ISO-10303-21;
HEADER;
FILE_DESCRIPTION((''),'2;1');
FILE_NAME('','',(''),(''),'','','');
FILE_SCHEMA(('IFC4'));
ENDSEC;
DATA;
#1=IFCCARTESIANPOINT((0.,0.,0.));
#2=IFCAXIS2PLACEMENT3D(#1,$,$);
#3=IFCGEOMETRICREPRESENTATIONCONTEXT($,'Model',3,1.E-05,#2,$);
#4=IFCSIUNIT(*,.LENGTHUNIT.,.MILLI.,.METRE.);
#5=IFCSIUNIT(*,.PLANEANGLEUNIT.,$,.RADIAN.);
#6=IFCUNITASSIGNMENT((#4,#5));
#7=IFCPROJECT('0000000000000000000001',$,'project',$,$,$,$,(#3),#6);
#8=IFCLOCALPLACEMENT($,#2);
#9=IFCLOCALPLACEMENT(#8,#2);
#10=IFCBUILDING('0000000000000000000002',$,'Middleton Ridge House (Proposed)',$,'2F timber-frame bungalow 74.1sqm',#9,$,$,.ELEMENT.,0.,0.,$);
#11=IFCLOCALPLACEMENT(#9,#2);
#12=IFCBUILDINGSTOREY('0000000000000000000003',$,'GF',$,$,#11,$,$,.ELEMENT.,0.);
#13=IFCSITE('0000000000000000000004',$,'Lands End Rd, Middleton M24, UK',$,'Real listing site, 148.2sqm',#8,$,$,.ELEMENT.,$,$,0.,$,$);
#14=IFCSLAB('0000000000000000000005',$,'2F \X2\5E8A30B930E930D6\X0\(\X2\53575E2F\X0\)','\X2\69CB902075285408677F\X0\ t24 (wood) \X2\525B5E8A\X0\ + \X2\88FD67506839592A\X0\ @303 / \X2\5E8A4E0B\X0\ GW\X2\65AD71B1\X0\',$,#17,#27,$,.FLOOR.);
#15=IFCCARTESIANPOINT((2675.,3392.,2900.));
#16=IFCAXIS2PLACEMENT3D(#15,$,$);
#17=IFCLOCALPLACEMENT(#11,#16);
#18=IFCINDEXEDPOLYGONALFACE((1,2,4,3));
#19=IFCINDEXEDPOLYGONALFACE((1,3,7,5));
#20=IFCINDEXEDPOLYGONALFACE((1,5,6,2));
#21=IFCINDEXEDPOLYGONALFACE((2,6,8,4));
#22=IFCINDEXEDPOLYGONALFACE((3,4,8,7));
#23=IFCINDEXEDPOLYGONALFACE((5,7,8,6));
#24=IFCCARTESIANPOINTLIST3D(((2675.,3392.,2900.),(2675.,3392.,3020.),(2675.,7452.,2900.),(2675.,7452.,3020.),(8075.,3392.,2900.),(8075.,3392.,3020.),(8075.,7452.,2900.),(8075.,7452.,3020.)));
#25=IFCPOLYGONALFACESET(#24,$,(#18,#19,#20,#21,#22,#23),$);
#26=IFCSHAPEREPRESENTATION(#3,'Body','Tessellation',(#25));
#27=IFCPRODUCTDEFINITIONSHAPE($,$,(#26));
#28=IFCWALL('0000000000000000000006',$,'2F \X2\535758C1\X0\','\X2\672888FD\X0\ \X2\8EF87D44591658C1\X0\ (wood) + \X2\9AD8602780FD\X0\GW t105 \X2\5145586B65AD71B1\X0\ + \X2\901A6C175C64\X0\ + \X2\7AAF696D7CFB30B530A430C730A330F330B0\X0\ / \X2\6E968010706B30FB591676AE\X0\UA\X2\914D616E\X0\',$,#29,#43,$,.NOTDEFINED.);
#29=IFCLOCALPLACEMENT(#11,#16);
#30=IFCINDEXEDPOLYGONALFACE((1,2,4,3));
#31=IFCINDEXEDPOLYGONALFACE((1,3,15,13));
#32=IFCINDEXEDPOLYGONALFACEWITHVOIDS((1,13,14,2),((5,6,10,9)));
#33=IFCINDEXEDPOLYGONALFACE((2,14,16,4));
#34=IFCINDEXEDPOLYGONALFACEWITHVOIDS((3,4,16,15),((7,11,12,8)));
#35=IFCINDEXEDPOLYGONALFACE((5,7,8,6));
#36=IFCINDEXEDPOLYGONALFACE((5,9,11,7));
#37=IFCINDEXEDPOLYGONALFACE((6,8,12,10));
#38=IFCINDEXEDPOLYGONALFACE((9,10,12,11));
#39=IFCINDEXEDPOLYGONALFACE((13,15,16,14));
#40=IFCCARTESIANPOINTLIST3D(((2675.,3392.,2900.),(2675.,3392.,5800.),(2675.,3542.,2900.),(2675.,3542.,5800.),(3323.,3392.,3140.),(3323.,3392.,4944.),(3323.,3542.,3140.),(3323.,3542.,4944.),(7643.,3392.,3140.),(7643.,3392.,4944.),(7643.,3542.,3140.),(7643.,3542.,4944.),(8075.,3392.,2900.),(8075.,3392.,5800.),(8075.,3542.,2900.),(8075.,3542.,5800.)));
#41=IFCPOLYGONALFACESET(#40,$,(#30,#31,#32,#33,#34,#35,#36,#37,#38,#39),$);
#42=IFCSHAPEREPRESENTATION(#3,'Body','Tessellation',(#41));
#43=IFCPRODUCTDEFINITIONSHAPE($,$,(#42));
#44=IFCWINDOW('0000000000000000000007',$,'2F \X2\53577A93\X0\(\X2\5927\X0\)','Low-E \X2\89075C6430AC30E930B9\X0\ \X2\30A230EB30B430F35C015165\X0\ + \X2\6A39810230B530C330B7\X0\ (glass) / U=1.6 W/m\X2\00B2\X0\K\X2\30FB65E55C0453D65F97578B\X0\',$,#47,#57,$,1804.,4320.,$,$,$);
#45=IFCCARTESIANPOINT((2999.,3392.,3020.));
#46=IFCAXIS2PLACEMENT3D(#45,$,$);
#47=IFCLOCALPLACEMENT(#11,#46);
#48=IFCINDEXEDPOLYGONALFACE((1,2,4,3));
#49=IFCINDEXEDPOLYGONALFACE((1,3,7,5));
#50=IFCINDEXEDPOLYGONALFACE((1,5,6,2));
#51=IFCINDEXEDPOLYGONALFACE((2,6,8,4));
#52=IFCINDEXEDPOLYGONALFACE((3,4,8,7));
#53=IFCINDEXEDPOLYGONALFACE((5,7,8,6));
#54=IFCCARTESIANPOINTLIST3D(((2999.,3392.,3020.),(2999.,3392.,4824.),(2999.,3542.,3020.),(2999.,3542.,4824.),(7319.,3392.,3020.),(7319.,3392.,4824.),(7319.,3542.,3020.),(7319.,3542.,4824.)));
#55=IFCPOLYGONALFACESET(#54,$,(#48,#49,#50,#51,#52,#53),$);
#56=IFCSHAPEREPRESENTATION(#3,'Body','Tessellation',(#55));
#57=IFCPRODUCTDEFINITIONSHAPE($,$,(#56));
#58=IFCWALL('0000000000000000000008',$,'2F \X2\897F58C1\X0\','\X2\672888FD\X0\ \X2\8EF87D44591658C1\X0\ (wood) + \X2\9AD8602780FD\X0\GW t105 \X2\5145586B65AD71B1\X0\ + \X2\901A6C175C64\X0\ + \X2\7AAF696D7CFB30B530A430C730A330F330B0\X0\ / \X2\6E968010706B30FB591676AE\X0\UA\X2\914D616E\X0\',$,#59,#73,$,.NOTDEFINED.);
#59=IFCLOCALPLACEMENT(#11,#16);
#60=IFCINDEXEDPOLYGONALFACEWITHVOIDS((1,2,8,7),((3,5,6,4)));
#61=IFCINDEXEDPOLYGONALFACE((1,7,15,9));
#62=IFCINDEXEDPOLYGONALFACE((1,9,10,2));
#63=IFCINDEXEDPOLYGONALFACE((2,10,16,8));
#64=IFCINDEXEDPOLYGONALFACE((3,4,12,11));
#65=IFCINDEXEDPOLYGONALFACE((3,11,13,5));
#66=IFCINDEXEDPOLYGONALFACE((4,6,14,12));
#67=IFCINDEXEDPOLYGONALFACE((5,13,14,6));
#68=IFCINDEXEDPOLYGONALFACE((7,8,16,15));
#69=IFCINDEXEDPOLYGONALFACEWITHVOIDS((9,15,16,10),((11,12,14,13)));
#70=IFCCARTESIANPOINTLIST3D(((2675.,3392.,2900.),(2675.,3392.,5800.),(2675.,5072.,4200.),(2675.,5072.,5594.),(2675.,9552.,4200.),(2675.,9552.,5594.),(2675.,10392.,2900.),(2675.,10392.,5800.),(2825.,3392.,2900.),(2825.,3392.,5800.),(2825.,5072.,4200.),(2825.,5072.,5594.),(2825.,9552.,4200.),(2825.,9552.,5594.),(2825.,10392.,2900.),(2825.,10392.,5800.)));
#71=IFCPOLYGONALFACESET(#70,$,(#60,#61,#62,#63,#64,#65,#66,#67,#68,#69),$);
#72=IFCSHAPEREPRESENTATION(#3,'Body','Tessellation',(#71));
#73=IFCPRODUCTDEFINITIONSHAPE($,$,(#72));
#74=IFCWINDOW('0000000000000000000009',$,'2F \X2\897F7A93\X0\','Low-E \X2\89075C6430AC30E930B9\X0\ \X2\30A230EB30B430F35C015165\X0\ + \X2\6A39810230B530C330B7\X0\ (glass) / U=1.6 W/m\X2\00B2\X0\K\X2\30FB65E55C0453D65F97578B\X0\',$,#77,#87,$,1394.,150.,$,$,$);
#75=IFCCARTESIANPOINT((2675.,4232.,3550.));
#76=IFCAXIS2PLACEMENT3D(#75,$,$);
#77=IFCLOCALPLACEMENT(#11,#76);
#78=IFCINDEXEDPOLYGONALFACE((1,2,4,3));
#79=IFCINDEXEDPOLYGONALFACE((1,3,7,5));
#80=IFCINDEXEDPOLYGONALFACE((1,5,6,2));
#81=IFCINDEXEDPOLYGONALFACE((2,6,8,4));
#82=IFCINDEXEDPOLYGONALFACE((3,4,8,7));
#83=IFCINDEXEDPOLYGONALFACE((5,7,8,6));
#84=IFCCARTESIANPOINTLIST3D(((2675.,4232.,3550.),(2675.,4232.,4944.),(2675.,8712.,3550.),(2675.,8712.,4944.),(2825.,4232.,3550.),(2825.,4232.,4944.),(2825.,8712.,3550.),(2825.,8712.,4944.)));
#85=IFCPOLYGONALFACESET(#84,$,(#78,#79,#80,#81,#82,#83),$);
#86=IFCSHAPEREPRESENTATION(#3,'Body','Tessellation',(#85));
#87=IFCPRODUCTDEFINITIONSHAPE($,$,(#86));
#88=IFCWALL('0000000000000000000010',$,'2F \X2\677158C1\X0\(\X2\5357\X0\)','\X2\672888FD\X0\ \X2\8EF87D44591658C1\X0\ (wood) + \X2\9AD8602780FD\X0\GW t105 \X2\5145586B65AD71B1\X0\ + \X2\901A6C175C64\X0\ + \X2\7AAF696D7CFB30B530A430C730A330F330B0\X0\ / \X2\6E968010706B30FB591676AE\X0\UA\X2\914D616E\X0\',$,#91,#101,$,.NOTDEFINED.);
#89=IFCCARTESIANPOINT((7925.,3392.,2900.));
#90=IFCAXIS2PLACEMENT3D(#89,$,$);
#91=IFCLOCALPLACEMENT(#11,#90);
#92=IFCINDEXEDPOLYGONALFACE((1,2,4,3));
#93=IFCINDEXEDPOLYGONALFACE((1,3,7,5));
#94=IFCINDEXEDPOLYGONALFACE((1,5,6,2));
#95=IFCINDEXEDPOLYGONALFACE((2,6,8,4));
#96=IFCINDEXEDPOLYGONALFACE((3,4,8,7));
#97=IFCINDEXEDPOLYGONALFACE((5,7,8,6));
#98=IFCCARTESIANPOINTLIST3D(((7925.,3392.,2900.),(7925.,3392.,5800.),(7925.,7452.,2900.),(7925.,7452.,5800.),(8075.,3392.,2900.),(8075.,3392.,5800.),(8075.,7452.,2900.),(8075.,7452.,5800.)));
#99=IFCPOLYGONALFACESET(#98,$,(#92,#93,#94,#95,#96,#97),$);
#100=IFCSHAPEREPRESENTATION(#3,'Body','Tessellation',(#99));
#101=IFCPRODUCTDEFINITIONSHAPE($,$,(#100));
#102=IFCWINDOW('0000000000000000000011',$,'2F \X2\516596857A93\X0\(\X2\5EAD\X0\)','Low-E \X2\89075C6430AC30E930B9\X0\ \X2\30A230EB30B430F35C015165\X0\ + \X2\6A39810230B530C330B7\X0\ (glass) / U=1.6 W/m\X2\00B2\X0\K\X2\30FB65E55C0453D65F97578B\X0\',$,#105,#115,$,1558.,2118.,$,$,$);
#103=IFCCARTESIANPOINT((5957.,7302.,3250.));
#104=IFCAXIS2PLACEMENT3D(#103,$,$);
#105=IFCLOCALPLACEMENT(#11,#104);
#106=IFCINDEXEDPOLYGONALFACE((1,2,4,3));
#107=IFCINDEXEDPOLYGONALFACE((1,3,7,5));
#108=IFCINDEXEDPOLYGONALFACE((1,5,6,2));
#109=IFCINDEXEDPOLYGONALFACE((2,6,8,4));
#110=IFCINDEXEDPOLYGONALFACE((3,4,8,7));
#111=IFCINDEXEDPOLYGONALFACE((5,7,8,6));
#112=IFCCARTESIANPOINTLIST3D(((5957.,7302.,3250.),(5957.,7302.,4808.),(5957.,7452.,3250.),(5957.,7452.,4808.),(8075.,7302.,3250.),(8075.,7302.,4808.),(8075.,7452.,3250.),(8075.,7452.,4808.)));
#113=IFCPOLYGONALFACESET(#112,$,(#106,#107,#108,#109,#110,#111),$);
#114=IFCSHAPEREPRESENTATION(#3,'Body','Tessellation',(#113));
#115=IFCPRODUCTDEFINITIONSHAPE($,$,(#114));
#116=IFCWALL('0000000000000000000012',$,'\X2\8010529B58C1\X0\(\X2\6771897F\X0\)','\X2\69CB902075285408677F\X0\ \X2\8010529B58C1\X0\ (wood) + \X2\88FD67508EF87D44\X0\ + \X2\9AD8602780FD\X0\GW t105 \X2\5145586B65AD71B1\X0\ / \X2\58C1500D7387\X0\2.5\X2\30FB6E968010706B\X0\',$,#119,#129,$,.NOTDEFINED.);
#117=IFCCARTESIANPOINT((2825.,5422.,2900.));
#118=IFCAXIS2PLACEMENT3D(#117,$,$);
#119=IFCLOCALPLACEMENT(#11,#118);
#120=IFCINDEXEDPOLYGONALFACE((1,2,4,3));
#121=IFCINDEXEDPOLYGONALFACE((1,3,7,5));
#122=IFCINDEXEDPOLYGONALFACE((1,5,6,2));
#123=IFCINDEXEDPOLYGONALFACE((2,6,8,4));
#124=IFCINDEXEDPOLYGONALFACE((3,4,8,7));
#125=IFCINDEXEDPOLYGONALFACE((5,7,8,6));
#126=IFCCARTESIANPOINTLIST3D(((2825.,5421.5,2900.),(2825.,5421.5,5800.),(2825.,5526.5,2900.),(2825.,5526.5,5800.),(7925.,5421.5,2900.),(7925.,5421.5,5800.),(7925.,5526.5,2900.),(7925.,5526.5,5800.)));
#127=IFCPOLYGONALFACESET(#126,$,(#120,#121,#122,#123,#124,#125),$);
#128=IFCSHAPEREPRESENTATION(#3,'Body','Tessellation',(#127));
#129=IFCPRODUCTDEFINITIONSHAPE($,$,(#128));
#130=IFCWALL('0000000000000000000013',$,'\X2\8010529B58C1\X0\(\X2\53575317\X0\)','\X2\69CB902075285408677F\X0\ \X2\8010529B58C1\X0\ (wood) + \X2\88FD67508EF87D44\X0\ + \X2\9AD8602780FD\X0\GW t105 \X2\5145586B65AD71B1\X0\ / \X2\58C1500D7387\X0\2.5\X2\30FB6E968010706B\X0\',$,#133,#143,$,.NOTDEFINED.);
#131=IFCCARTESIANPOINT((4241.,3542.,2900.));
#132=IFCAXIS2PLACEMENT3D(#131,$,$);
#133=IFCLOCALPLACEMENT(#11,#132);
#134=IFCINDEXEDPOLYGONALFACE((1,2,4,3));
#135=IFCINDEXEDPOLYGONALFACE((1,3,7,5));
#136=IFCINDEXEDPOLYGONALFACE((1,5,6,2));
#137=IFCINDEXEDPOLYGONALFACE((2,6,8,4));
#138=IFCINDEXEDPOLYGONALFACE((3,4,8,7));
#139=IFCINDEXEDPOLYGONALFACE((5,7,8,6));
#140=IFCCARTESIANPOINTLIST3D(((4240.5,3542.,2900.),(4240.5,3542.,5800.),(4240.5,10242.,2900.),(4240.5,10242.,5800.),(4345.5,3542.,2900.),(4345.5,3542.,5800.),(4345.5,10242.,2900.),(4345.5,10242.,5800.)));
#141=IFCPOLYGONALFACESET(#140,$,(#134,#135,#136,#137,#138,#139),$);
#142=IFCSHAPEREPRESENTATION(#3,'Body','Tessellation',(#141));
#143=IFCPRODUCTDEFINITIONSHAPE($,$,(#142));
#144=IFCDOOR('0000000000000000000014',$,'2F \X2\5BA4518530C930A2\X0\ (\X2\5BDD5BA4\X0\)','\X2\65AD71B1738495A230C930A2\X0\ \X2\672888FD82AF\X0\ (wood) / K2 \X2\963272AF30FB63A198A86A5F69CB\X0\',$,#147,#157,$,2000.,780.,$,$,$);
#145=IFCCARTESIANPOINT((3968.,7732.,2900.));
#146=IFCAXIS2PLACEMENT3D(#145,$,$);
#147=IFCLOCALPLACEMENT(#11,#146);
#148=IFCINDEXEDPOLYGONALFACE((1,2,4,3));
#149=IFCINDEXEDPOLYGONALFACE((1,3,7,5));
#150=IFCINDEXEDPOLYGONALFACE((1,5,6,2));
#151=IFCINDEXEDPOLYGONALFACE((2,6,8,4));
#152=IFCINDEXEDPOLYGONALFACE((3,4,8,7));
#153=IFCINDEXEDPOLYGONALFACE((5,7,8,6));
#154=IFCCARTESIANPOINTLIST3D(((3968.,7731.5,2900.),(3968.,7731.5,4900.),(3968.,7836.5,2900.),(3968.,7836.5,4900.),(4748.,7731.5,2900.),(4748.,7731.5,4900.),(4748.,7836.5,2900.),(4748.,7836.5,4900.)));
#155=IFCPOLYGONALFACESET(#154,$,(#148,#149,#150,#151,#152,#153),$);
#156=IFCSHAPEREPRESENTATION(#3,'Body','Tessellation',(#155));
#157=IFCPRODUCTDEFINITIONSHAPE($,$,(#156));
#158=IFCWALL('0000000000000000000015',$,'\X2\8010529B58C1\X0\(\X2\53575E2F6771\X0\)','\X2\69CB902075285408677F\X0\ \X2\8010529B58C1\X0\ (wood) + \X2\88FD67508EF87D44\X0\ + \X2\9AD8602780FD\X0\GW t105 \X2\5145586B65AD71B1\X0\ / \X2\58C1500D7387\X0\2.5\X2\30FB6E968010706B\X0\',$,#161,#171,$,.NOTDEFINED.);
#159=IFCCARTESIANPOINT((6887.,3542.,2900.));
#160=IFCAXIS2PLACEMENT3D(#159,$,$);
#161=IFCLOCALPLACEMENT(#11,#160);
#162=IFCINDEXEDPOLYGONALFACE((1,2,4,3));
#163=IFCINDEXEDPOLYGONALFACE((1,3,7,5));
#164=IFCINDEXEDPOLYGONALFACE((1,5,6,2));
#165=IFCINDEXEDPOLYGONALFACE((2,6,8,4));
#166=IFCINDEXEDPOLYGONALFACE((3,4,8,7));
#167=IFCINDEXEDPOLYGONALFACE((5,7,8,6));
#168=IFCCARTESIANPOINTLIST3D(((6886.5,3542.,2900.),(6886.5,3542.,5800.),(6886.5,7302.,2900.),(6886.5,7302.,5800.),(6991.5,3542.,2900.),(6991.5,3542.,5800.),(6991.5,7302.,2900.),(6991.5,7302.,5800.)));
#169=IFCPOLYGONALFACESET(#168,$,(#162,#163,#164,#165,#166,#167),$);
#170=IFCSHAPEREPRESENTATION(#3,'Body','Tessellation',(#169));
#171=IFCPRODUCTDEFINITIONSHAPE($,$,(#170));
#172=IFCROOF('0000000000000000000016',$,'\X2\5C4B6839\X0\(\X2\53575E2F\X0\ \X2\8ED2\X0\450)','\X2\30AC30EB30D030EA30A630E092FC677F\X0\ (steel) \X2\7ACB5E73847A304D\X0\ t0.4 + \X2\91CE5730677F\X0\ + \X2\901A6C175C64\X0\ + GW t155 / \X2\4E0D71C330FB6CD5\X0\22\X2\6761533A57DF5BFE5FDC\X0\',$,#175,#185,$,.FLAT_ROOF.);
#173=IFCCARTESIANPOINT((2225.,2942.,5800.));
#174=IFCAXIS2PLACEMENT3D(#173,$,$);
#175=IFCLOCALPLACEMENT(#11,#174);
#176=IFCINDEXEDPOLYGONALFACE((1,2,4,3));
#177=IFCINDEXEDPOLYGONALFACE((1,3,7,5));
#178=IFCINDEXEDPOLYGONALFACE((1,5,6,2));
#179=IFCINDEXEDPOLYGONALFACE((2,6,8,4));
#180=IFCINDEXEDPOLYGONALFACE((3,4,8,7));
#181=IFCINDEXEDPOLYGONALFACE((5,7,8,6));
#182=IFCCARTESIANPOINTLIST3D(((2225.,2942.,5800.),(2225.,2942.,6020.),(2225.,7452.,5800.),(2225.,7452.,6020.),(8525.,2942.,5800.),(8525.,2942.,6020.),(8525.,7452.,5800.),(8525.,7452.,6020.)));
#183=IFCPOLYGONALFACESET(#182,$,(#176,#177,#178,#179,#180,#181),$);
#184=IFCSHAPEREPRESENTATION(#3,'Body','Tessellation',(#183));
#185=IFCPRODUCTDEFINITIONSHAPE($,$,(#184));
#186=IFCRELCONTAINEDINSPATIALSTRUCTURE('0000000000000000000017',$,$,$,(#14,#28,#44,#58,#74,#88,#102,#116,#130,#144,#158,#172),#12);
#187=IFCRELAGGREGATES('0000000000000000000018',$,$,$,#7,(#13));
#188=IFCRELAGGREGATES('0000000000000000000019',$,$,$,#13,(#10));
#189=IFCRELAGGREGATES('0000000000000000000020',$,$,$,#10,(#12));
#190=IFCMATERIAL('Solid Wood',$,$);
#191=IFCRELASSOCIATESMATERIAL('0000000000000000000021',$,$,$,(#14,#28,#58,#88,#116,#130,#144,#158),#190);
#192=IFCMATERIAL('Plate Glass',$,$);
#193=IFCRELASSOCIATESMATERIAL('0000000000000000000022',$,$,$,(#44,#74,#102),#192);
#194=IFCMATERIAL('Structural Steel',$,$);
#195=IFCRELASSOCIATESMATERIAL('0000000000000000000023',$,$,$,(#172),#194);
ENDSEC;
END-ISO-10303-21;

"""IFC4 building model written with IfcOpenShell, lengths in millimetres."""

from ifc_helpers import new_model, si_unit, frame, frame_2d, origin, place, context, project, spatial, rectangle, extrude, material, element, fill, save


model = new_model("IFC4")

# Units and contexts
model_context = context("Model", 3, precision=1e-05, world=origin())
ifc_project = project(units=[si_unit("LENGTHUNIT", "METRE", prefix="MILLI"), si_unit("PLANEANGLEUNIT", "RADIAN")], contexts=[model_context])

# Site, building, storey
site_placement = place(None, origin())
site = spatial("IfcSite", under=ifc_project, at=site_placement, Name="Lands End Rd, Middleton M24, UK", ObjectType="Real listing site, 148.2sqm", CompositionType="ELEMENT", RefElevation=0.0)
building_placement = place(site_placement, origin())
building = spatial("IfcBuilding", under=site, at=building_placement, Name="Middleton Ridge House (Proposed)", ObjectType="2F timber-frame bungalow 74.1sqm", CompositionType="ELEMENT", ElevationOfRefHeight=0.0, ElevationOfTerrain=0.0)
storey_placement = place(building_placement, origin())
storey = spatial("IfcBuildingStorey", under=building, at=storey_placement, Name="GF", CompositionType="ELEMENT", Elevation=0.0)

# Slab
ifc_material_1 = material(Name="Solid Wood")
slab_placement = place(storey_placement, frame((2675.0, 3392.0, 2900.0)))
element("IfcSlab", 1, at=slab_placement, inside=storey, material=ifc_material_1, Name="2F 床スラブ(南帯)", Description="構造用合板 t24 (wood) 剛床 + 製材根太 @303 / 床下 GW断熱", PredefinedType="FLOOR", context=model_context, shape_type="SweptSolid", body=[
    extrude(rectangle(XDim=5400.0, YDim=4060.0, at=frame_2d((2700.0, 2030.0))), frame((2675.0, 3392.0, 2900.0)), (0.0, 0.0, 1.0), 120.0),
])

# Walls, openings, windows
wall_1_placement = place(storey_placement, frame((2675.0, 3392.0, 2900.0)))
wall_1 = element("IfcWall", 2, at=wall_1_placement, inside=storey, material=ifc_material_1, Name="2F 南壁", Description="木製 軸組外壁 (wood) + 高性能GW t105 充填断熱 + 通気層 + 窯業系サイディング / 準耐火・外皮UA配慮", PredefinedType="NOTDEFINED", context=model_context, shape_type="SweptSolid", body=[
    extrude(rectangle(XDim=5400.0, YDim=150.0, at=frame_2d((2700.0, 75.0))), frame((2675.0, 3392.0, 2900.0)), (0.0, 0.0, 1.0), 2900.0),
])
opening_1_placement = place(storey_placement, frame((2999.0, 3392.0, 3020.0)))
opening_1 = element("IfcOpeningElement", 3, at=opening_1_placement, cuts=wall_1, PredefinedType="NOTDEFINED", context=model_context, shape_type="SweptSolid", body=[
    extrude(rectangle(XDim=4320.0, YDim=150.0, at=frame_2d((2160.0, 75.0))), frame((2999.0, 3392.0, 3020.0)), (0.0, 0.0, 1.0), 1804.0),
])
ifc_material_2 = material(Name="Plate Glass")
window_1_placement = place(storey_placement, frame((2999.0, 3392.0, 3020.0)))
window_1 = element("IfcWindow", 4, at=window_1_placement, inside=storey, material=ifc_material_2, Name="2F 南窓(大)", Description="Low-E 複層ガラス アルゴン封入 + 樹脂サッシ (glass) / U=1.6 W/m²K・日射取得型", OverallHeight=1804.0, OverallWidth=4320.0, context=model_context, shape_type="SweptSolid", body=[
    extrude(rectangle(XDim=4320.0, YDim=150.0, at=frame_2d((2160.0, 75.0))), frame((2999.0, 3392.0, 3020.0)), (0.0, 0.0, 1.0), 1804.0),
])
fill(opening_1, window_1)
wall_2_placement = place(storey_placement, frame((2675.0, 3392.0, 2900.0)))
wall_2 = element("IfcWall", 5, at=wall_2_placement, inside=storey, material=ifc_material_1, Name="2F 西壁", Description="木製 軸組外壁 (wood) + 高性能GW t105 充填断熱 + 通気層 + 窯業系サイディング / 準耐火・外皮UA配慮", PredefinedType="NOTDEFINED", context=model_context, shape_type="SweptSolid", body=[
    extrude(rectangle(XDim=150.0, YDim=7000.0, at=frame_2d((75.0, 3500.0))), frame((2675.0, 3392.0, 2900.0)), (0.0, 0.0, 1.0), 2900.0),
])
opening_2_placement = place(storey_placement, frame((2675.0, 4232.0, 3550.0)))
opening_2 = element("IfcOpeningElement", 6, at=opening_2_placement, cuts=wall_2, PredefinedType="NOTDEFINED", context=model_context, shape_type="SweptSolid", body=[
    extrude(rectangle(XDim=150.0, YDim=4480.0, at=frame_2d((75.0, 2240.0))), frame((2675.0, 4232.0, 3550.0)), (0.0, 0.0, 1.0), 1394.0),
])
window_2_placement = place(storey_placement, frame((2675.0, 4232.0, 3550.0)))
window_2 = element("IfcWindow", 7, at=window_2_placement, inside=storey, material=ifc_material_2, Name="2F 西窓", Description="Low-E 複層ガラス アルゴン封入 + 樹脂サッシ (glass) / U=1.6 W/m²K・日射取得型", OverallHeight=1394.0, OverallWidth=150.0, context=model_context, shape_type="SweptSolid", body=[
    extrude(rectangle(XDim=150.0, YDim=4480.0, at=frame_2d((75.0, 2240.0))), frame((2675.0, 4232.0, 3550.0)), (0.0, 0.0, 1.0), 1394.0),
])
fill(opening_2, window_2)
wall_3_placement = place(storey_placement, frame((7925.0, 3392.0, 2900.0)))
wall_3 = element("IfcWall", 8, at=wall_3_placement, inside=storey, material=ifc_material_1, Name="2F 東壁(南)", Description="木製 軸組外壁 (wood) + 高性能GW t105 充填断熱 + 通気層 + 窯業系サイディング / 準耐火・外皮UA配慮", PredefinedType="NOTDEFINED", context=model_context, shape_type="SweptSolid", body=[
    extrude(rectangle(XDim=150.0, YDim=4060.0, at=frame_2d((75.0, 2030.0))), frame((7925.0, 3392.0, 2900.0)), (0.0, 0.0, 1.0), 2900.0),
])
opening_3_placement = place(storey_placement, frame((5957.0, 7302.0, 3250.0)))
opening_3 = element("IfcOpeningElement", 9, at=opening_3_placement, cuts=wall_3, PredefinedType="NOTDEFINED", context=model_context, shape_type="SweptSolid", body=[
    extrude(rectangle(XDim=2118.0, YDim=150.0, at=frame_2d((1059.0, 75.0))), frame((5957.0, 7302.0, 3250.0)), (0.0, 0.0, 1.0), 1558.0),
])
window_3_placement = place(storey_placement, frame((5957.0, 7302.0, 3250.0)))
window_3 = element("IfcWindow", 10, at=window_3_placement, inside=storey, material=ifc_material_2, Name="2F 入隅窓(庭)", Description="Low-E 複層ガラス アルゴン封入 + 樹脂サッシ (glass) / U=1.6 W/m²K・日射取得型", OverallHeight=1558.0, OverallWidth=2118.0, context=model_context, shape_type="SweptSolid", body=[
    extrude(rectangle(XDim=2118.0, YDim=150.0, at=frame_2d((1059.0, 75.0))), frame((5957.0, 7302.0, 3250.0)), (0.0, 0.0, 1.0), 1558.0),
])
fill(opening_3, window_3)

# Wall
wall_4_placement = place(storey_placement, frame((2825.0, 5422.0, 2900.0)))
element("IfcWall", 11, at=wall_4_placement, inside=storey, material=ifc_material_1, Name="耐力壁(東西)", Description="構造用合板 耐力壁 (wood) + 製材軸組 + 高性能GW t105 充填断熱 / 壁倍率2.5・準耐火", PredefinedType="NOTDEFINED", context=model_context, shape_type="SweptSolid", body=[
    extrude(rectangle(XDim=5100.0, YDim=105.0, at=frame_2d((2550.0, 52.0))), frame((2825.0, 5422.0, 2900.0)), (0.0, 0.0, 1.0), 2900.0),
])

# Wall, opening, door
wall_5_placement = place(storey_placement, frame((4241.0, 3542.0, 2900.0)))
wall_5 = element("IfcWall", 12, at=wall_5_placement, inside=storey, material=ifc_material_1, Name="耐力壁(南北)", Description="構造用合板 耐力壁 (wood) + 製材軸組 + 高性能GW t105 充填断熱 / 壁倍率2.5・準耐火", PredefinedType="NOTDEFINED", context=model_context, shape_type="SweptSolid", body=[
    extrude(rectangle(XDim=105.0, YDim=6700.0, at=frame_2d((52.0, 3350.0))), frame((4241.0, 3542.0, 2900.0)), (0.0, 0.0, 1.0), 2900.0),
])
opening_4_placement = place(storey_placement, frame((3968.0, 7732.0, 2900.0)))
opening_4 = element("IfcOpeningElement", 13, at=opening_4_placement, cuts=wall_5, PredefinedType="NOTDEFINED", context=model_context, shape_type="SweptSolid", body=[
    extrude(rectangle(XDim=780.0, YDim=105.0, at=frame_2d((390.0, 52.0))), frame((3968.0, 7732.0, 2900.0)), (0.0, 0.0, 1.0), 2000.0),
])
door_placement = place(storey_placement, frame((3968.0, 7732.0, 2900.0)))
door = element("IfcDoor", 14, at=door_placement, inside=storey, material=ifc_material_1, Name="2F 室内ドア (寝室)", Description="断熱玄関ドア 木製芯 (wood) / K2 防犯・採風機構", OverallHeight=2000.0, OverallWidth=780.0, context=model_context, shape_type="SweptSolid", body=[
    extrude(rectangle(XDim=780.0, YDim=105.0, at=frame_2d((390.0, 52.0))), frame((3968.0, 7732.0, 2900.0)), (0.0, 0.0, 1.0), 2000.0),
])
fill(opening_4, door)

# Wall
wall_6_placement = place(storey_placement, frame((6887.0, 3542.0, 2900.0)))
element("IfcWall", 15, at=wall_6_placement, inside=storey, material=ifc_material_1, Name="耐力壁(南帯東)", Description="構造用合板 耐力壁 (wood) + 製材軸組 + 高性能GW t105 充填断熱 / 壁倍率2.5・準耐火", PredefinedType="NOTDEFINED", context=model_context, shape_type="SweptSolid", body=[
    extrude(rectangle(XDim=105.0, YDim=3760.0, at=frame_2d((52.0, 1880.0))), frame((6887.0, 3542.0, 2900.0)), (0.0, 0.0, 1.0), 2900.0),
])

# Roof
ifc_material_3 = material(Name="Structural Steel")
for number, where, name in (
    (16, (2225.0, 2942.0, 5800.0), "屋根(南帯 軒450)"),
):
    element("IfcRoof", number, at=place(storey_placement, frame(where)), inside=storey, material=ifc_material_3, Name=name, Description="ガルバリウム鋼板 (steel) 立平葺き t0.4 + 野地板 + 通気層 + GW t155 / 不燃・法22条区域対応", PredefinedType="FLAT_ROOF", context=model_context, shape_type="SweptSolid", body=[
        extrude(rectangle(XDim=6300.0, YDim=4510.0, at=frame_2d((3150.0, 2255.0))), frame((2225.0, 2942.0, 5800.0)), (0.0, 0.0, 1.0), 220.0),
    ])

save(model, "model.ifc")
